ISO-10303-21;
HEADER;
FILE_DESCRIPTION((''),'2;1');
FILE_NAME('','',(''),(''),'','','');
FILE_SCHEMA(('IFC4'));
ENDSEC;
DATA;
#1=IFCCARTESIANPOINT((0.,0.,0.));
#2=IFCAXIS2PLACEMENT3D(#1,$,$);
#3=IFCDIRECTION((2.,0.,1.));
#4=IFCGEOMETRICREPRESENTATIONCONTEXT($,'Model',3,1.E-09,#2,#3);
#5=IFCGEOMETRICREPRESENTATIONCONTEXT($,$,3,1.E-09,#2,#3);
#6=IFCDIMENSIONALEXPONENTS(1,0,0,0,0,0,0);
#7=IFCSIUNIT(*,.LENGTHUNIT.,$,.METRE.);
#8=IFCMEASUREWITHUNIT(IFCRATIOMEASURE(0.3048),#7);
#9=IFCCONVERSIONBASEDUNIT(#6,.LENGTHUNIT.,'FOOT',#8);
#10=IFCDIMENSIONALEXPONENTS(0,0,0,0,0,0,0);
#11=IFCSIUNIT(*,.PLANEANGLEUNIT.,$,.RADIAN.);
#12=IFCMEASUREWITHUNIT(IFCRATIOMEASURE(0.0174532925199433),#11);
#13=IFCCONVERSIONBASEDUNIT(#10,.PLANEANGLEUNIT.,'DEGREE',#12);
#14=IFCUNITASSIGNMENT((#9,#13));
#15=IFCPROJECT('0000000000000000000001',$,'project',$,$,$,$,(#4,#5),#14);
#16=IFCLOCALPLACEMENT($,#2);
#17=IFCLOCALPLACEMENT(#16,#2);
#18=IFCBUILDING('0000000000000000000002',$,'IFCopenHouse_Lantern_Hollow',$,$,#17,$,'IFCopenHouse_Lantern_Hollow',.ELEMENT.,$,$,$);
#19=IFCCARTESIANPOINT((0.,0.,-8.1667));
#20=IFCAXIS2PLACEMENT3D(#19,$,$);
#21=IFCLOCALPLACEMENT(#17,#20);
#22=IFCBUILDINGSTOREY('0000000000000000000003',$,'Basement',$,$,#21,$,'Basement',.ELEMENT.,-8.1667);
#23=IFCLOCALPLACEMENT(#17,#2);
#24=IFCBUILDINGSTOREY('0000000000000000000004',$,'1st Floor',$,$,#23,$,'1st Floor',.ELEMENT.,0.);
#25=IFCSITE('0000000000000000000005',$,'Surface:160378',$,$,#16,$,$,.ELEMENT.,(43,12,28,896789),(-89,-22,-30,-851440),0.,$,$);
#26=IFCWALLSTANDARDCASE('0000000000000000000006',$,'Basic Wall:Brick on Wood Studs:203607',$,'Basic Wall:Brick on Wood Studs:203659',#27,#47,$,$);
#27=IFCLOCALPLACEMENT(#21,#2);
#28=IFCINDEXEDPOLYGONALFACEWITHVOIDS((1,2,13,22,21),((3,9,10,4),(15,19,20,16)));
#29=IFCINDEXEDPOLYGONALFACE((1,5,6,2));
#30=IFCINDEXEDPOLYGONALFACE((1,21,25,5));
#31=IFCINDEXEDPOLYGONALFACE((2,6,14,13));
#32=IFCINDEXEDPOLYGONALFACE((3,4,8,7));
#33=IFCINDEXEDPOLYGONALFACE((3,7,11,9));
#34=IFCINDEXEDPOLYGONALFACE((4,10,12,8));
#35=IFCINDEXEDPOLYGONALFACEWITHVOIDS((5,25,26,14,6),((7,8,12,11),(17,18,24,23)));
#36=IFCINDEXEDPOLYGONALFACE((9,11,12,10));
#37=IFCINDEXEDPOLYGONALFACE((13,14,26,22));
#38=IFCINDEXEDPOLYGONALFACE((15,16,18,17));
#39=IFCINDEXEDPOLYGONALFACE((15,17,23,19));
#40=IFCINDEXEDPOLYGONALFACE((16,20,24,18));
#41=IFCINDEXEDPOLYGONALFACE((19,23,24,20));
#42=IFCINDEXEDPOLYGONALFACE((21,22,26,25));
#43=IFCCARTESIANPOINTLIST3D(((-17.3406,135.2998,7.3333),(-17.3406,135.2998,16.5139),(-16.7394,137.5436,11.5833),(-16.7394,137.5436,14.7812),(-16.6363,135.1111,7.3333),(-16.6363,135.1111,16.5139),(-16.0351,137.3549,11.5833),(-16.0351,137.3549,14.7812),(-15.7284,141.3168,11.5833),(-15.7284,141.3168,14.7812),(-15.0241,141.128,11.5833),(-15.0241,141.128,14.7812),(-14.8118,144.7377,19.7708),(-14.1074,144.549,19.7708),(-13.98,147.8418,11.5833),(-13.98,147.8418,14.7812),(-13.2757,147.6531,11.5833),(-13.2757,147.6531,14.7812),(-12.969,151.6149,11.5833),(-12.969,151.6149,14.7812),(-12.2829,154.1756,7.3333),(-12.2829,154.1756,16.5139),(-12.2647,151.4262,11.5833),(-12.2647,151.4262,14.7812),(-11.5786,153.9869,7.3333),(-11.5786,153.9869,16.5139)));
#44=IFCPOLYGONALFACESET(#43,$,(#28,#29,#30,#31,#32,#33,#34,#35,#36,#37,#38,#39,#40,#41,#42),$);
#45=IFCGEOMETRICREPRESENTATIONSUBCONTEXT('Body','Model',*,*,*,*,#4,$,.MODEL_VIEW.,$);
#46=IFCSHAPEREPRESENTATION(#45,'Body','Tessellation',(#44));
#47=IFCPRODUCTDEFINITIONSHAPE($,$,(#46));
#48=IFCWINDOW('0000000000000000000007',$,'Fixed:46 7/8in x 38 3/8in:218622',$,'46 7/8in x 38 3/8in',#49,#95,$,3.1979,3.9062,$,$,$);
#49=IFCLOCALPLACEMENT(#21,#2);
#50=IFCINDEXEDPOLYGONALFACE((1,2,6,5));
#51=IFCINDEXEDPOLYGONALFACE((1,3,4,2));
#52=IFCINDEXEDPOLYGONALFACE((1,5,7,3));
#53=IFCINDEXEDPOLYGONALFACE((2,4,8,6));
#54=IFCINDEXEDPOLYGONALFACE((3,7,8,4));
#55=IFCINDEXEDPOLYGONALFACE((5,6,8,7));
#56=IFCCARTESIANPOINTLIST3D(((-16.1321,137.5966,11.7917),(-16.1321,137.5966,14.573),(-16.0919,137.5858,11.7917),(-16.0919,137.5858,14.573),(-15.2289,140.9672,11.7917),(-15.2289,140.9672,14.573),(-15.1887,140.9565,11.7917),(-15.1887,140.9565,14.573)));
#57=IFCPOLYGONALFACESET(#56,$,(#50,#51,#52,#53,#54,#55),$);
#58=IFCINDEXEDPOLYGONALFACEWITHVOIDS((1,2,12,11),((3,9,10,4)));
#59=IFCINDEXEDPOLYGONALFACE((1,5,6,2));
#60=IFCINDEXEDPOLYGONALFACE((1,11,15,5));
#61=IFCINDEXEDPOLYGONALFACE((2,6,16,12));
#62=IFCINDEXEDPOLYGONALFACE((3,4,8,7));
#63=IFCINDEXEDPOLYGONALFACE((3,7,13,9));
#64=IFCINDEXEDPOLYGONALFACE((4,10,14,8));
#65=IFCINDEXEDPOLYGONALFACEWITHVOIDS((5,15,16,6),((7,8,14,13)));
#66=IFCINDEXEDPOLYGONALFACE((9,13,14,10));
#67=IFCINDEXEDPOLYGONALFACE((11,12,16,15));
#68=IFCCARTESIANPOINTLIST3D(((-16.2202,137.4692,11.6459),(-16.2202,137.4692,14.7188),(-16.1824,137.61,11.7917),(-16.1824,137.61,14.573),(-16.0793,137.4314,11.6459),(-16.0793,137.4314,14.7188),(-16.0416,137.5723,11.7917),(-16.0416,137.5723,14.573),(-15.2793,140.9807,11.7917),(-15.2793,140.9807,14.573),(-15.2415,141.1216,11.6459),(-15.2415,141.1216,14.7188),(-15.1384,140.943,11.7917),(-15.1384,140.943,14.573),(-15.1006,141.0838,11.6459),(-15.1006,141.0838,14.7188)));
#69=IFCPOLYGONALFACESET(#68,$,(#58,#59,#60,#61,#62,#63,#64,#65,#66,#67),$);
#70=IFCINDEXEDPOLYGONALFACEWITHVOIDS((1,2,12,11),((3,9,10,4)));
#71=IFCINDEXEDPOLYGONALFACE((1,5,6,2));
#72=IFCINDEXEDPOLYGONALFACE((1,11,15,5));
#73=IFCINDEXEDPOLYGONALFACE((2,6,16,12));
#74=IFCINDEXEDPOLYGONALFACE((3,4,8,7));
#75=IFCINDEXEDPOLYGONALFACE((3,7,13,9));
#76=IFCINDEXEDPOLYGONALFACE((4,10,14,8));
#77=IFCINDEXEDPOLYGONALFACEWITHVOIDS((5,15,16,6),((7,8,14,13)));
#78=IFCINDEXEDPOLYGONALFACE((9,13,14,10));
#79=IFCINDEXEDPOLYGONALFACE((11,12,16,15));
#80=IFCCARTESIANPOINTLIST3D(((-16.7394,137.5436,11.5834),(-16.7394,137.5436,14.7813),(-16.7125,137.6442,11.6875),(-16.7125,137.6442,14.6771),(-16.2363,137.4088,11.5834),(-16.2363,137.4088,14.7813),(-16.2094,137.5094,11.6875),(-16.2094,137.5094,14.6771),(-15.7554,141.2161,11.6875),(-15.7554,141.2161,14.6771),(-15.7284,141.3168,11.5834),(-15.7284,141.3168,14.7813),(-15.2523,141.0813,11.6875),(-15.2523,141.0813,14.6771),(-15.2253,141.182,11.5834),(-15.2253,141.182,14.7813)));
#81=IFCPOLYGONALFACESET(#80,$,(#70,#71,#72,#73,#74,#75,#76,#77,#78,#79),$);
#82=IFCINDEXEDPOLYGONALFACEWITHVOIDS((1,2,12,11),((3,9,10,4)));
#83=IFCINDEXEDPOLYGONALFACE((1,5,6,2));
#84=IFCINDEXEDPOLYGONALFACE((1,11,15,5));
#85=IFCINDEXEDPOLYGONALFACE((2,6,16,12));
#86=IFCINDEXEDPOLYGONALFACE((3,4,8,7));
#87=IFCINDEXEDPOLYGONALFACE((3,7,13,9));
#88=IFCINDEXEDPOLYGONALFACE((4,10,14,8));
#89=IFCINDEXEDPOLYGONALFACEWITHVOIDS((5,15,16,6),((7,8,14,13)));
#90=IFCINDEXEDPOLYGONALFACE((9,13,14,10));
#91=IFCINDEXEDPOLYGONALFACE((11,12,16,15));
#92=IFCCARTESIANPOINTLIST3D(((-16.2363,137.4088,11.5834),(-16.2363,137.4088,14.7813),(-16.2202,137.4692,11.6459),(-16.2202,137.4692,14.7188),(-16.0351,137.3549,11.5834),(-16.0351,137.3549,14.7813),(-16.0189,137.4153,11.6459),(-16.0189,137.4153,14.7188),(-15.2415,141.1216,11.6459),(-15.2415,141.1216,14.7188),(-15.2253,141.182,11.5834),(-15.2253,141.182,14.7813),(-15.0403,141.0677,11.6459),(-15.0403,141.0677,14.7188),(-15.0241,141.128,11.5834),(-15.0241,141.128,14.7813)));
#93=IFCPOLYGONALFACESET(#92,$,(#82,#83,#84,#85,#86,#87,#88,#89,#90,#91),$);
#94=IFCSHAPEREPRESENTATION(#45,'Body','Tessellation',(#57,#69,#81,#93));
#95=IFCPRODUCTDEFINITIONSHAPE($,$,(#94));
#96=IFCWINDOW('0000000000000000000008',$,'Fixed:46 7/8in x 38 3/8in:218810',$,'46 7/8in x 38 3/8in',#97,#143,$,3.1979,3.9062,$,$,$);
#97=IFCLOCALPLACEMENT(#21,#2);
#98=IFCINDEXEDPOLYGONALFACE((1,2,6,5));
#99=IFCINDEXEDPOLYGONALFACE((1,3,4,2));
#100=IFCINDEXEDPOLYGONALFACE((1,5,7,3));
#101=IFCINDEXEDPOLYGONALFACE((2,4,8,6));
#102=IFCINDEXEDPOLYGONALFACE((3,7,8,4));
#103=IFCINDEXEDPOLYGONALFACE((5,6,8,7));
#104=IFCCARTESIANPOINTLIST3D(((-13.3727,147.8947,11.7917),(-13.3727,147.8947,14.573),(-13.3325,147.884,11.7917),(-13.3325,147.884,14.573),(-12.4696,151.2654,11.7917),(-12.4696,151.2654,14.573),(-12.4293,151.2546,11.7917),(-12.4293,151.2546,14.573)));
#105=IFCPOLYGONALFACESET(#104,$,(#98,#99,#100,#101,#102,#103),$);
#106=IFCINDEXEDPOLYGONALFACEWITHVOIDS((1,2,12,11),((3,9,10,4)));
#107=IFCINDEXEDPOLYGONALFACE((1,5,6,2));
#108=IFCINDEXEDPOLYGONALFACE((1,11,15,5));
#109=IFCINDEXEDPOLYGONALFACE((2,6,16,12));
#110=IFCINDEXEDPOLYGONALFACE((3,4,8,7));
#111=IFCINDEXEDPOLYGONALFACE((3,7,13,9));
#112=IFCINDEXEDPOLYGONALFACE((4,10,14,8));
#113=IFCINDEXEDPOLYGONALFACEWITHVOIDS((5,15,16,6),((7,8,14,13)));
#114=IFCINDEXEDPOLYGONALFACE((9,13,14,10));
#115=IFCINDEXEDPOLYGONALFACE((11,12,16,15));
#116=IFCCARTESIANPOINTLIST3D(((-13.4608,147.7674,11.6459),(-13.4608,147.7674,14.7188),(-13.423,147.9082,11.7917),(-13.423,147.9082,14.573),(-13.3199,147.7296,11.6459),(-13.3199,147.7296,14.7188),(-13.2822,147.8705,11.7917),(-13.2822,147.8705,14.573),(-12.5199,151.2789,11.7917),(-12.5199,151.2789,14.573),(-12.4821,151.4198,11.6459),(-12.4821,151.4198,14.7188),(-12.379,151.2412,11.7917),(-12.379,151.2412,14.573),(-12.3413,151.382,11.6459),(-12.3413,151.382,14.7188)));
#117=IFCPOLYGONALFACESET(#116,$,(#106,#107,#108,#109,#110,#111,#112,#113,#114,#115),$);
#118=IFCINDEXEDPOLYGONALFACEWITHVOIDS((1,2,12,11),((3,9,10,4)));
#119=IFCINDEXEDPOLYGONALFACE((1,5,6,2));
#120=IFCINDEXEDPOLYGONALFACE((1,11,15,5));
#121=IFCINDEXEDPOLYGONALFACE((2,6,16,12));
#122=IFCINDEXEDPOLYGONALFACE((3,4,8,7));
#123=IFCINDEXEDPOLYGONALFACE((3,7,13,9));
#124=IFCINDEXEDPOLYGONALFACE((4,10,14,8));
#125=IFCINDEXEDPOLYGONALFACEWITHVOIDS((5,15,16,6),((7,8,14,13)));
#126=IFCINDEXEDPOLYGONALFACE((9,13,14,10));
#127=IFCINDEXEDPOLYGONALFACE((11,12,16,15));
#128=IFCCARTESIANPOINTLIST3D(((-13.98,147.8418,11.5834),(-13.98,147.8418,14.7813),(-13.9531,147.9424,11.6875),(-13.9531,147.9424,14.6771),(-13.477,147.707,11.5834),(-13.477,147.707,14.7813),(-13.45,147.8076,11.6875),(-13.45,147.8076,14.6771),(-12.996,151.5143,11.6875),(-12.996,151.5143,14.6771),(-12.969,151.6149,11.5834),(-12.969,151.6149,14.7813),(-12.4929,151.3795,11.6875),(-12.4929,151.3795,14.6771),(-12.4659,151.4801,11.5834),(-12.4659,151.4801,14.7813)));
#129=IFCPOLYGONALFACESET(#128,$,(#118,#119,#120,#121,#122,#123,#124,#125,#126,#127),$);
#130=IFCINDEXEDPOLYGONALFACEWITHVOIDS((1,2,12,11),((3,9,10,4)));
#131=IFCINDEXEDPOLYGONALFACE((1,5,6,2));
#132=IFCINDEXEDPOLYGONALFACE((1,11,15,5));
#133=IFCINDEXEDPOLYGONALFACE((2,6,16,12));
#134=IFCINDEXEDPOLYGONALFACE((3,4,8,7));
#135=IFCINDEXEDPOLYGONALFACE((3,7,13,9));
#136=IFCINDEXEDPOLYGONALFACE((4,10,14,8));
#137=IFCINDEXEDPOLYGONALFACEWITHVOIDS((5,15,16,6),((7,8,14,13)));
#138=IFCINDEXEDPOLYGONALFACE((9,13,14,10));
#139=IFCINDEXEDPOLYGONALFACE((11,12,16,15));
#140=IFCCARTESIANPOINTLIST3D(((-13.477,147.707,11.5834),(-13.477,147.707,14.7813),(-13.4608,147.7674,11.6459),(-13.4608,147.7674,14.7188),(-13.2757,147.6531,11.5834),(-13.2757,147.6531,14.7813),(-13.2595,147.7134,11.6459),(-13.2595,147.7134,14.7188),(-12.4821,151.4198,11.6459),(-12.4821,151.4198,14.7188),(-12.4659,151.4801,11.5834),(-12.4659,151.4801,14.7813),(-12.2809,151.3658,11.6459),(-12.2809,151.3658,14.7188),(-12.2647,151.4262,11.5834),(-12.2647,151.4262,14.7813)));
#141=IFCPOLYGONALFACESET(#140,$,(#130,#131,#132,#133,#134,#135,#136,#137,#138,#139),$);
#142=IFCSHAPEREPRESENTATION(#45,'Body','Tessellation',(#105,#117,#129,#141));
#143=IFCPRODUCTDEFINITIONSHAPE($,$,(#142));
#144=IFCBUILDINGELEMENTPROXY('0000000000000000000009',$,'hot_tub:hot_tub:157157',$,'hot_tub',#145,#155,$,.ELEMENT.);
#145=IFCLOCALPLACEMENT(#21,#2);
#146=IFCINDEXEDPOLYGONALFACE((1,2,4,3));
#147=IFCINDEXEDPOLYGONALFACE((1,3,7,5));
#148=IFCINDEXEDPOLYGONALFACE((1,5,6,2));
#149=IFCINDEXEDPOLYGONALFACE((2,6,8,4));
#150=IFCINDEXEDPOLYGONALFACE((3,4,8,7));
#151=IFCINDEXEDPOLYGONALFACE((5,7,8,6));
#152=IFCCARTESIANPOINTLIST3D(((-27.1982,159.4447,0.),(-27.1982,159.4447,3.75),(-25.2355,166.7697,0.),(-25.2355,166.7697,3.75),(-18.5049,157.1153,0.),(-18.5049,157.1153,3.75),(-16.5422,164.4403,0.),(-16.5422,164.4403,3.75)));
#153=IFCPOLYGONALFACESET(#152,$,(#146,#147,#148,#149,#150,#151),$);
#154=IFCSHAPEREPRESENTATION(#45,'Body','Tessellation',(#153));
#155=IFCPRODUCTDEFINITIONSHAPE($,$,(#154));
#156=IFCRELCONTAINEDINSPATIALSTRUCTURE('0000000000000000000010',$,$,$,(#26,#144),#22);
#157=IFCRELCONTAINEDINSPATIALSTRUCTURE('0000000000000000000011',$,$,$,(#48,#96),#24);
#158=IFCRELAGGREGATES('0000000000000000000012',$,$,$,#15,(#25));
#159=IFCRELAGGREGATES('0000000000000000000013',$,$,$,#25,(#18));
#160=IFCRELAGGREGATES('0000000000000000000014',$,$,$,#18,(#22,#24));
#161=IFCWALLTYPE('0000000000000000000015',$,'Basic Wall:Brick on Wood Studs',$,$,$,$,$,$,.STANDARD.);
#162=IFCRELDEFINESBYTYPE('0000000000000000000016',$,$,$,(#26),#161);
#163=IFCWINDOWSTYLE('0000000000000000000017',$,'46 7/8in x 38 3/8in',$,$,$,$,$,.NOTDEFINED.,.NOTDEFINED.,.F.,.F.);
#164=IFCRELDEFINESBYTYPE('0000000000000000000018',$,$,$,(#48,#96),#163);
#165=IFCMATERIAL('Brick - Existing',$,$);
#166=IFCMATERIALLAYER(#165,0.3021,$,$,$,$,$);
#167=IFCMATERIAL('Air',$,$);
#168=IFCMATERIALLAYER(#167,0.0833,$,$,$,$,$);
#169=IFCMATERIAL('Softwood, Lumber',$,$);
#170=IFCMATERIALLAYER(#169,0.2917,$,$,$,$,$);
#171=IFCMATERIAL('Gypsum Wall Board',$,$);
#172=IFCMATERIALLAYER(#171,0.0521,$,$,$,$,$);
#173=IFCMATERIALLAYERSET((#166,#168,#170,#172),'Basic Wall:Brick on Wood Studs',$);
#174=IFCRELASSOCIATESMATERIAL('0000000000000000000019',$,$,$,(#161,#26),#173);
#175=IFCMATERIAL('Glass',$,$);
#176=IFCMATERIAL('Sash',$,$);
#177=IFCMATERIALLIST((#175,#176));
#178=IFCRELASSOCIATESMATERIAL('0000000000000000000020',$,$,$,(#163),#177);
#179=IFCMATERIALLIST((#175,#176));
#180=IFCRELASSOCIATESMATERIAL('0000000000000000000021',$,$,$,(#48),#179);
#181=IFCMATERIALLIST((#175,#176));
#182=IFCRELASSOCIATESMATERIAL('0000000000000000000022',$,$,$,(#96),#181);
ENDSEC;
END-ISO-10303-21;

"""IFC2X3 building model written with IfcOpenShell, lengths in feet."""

from ifc_helpers import new_model, entity, si_unit, converted_unit, direction, frame, frame_2d, origin, origin_2d_with_axis, place, context, subcontext, project, spatial, polyline, rectangle, outline, extrude, clip, bounded_halfspace, source, transform, mapped, material, material_list, layer, layer_set, layer_usage, type_object, type_shapes, element, fill, save


model = new_model("IFC2X3")

# Units and contexts
model_context = context("Model", 3, precision=1e-09, world=origin(), true_north=direction((2.0, 0.0, 1.0)))
context_of_model = context(None, 3, precision=1e-09, world=origin(), true_north=direction((2.0, 0.0, 1.0)))
body_context = subcontext(model_context, "Body", "Model", "MODEL_VIEW")
ifc_project = project(units=[converted_unit("LENGTHUNIT", "FOOT", entity("IfcRatioMeasure", 0.3048), si_unit("LENGTHUNIT", "METRE"), dimensions=[1, 0, 0, 0, 0, 0, 0]), converted_unit("PLANEANGLEUNIT", "DEGREE", entity("IfcRatioMeasure", 0.0174532925199433), si_unit("PLANEANGLEUNIT", "RADIAN"), dimensions=[0, 0, 0, 0, 0, 0, 0])], contexts=[model_context, context_of_model])

# Site, building, storey
site_placement = place(None, origin())
site = spatial("IfcSite", under=ifc_project, at=site_placement, Name="Surface:160378", CompositionType="ELEMENT", RefLatitude=(43, 12, 28, 896789), RefLongitude=(-89, -22, -30, -851440), RefElevation=0.0)
building_placement = place(site_placement, origin())
building = spatial("IfcBuilding", under=site, at=building_placement, Name="IFCopenHouse_Lantern_Hollow", LongName="IFCopenHouse_Lantern_Hollow", CompositionType="ELEMENT")
storey_1_placement = place(building_placement, frame((0.0, 0.0, -8.1667)))
storey_1 = spatial("IfcBuildingStorey", under=building, at=storey_1_placement, Name="Basement", LongName="Basement", CompositionType="ELEMENT", Elevation=-8.1667)

# Shared definitions
ifc_material_1 = material(Name="Brick - Existing")
ifc_material_2 = material(Name="Air")
ifc_material_3 = material(Name="Softwood, Lumber")
ifc_material_4 = material(Name="Gypsum Wall Board")
ifc_material_5 = material(Name="Glass")
ifc_material_6 = material(Name="Sash")

# Wall, openings
ifc_layer_1 = layer(ifc_material_1, 0.3021)
ifc_layer_2 = layer(ifc_material_2, 0.0833)
ifc_layer_3 = layer(ifc_material_3, 0.2917)
ifc_layer_4 = layer(ifc_material_4, 0.0521)
ifc_layer_set_1 = layer_set([ifc_layer_1, ifc_layer_2, ifc_layer_3, ifc_layer_4], Name="Basic Wall:Brick on Wood Studs")
ifc_layer_usage_1 = layer_usage(ifc_layer_set_1, "AXIS2", "NEGATIVE", 0.3646)
wall_type_1 = type_object("IfcWallType", Name="Basic Wall:Brick on Wood Studs", PredefinedType="STANDARD", material=ifc_layer_set_1)
wall_1_placement = place(storey_1_placement, frame((-11.9307, 154.0813, 7.3333), z_axis=(0.0, 0.0, 1.0), x_axis=(-0.258819, -0.965926, 0.0)))
wall_1 = element("IfcWallStandardCase", 1, at=wall_1_placement, inside=storey_1, type_object=wall_type_1, material=ifc_layer_usage_1, Name="Basic Wall:Brick on Wood Studs:203607", ObjectType="Basic Wall:Brick on Wood Studs:203659", context=body_context, shape_type="Clipping", body=[
    clip(clip(extrude(rectangle(XDim=19.5417, YDim=0.7292, at=frame_2d((9.7708, 0.0), x_axis=(-1.0, 0.0))), origin(), (0.0, 0.0, 1.0), 12.4375), bounded_halfspace(frame((9.7708, -0.3646, 12.4375), z_axis=(0.316228, 0.0, 0.948683), x_axis=(0.0, 1.0, 0.0)), False, frame((9.7708, -0.3646, 12.4375)), polyline([(0.0, 0.0), (9.7708, 0.0), (9.7708, 0.7292), (0.0, 0.7292), (0.0, 0.0)]))), bounded_halfspace(frame((0.0, -0.3646, 9.1806), z_axis=(-0.316228, 0.0, 0.948683), x_axis=(0.0, -1.0, 0.0)), False, frame((0.0, -0.3646, 9.1806)), polyline([(0.0, 0.0), (9.7708, 0.0), (9.7708, 0.7292), (0.0, 0.7292), (0.0, 0.0)]))),
])
opening_1_placement = place(wall_1_placement, frame((13.3125, -0.3646, 4.25)))
opening_1 = element("IfcOpeningElement", 2, at=opening_1_placement, cuts=wall_1, ObjectType="Opening", context=body_context, shape_type="SweptSolid", body=[
    extrude(rectangle(XDim=3.1979, YDim=3.9062, at=frame_2d((1.599, 1.9531), x_axis=(-1.0, 0.0))), frame((0.0, 0.0, 0.0), z_axis=(0.0, 1.0, 0.0), x_axis=(0.0, 0.0, 1.0)), (0.0, 0.0, 1.0), 0.7292),
])
opening_2_placement = place(wall_1_placement, frame((2.651, -0.3646, 4.25)))
opening_2 = element("IfcOpeningElement", 3, at=opening_2_placement, cuts=wall_1, ObjectType="Opening", context=body_context, shape_type="SweptSolid", body=[
    extrude(rectangle(XDim=3.1979, YDim=3.9062, at=frame_2d((1.599, 1.9531), x_axis=(-1.0, 0.0))), frame((0.0, 0.0, 0.0), z_axis=(0.0, 1.0, 0.0), x_axis=(0.0, 0.0, 1.0)), (0.0, 0.0, 1.0), 0.7292),
])

# Shared definitions
storey_2_placement = place(building_placement, origin())
storey_2 = spatial("IfcBuildingStorey", under=building, at=storey_2_placement, Name="1st Floor", LongName="1st Floor", CompositionType="ELEMENT", Elevation=0.0)

# Windows
ifc_material_list_1 = material_list([ifc_material_5, ifc_material_6])
ifc_material_list_2 = material_list([ifc_material_5, ifc_material_6])
window_style_1 = type_object("IfcWindowStyle", Name="46 7/8in x 38 3/8in", ConstructionType="NOTDEFINED", OperationType="NOTDEFINED", ParameterTakesPrecedence=False, Sizeable=False, material=ifc_material_list_2)
shared_shape_1 = source(origin(), body_context, "Body", "SweptSolid", [
    extrude(rectangle(XDim=0.0417, YDim=3.4896, at=frame_2d((0.0, 0.0), x_axis=(1.0, 0.0))), frame((1.9531, 0.5938, 0.2083), z_axis=(0.0, 0.0, 1.0), x_axis=(0.0, 1.0, 0.0)), (0.0, 0.0, 1.0), 2.7813),
    extrude(outline(polyline([(-1.8906, -1.5365), (1.8906, -1.5365), (1.8906, 1.5365), (-1.8906, 1.5365), (-1.8906, -1.5365)]), holes=[polyline([(-1.7448, -1.3906), (-1.7448, 1.3906), (1.7448, 1.3906), (1.7448, -1.3906), (-1.7448, -1.3906)])]), frame((1.9531, 0.5208, 1.599), z_axis=(0.0, 1.0, 0.0), x_axis=(1.0, 0.0, 0.0)), (0.0, 0.0, 1.0), 0.1458),
    extrude(outline(polyline([(-1.9531, -1.599), (1.9531, -1.599), (1.9531, 1.599), (-1.9531, 1.599), (-1.9531, -1.599)]), holes=[polyline([(-1.849, -1.4948), (-1.849, 1.4948), (1.849, 1.4948), (1.849, -1.4948), (-1.849, -1.4948)])]), frame((1.9531, 0.0, 1.599), z_axis=(0.0, 1.0, 0.0), x_axis=(1.0, 0.0, 0.0)), (0.0, 0.0, 1.0), 0.5208),
    extrude(outline(polyline([(-1.599, -1.9531), (1.599, -1.9531), (1.599, 1.9531), (-1.599, 1.9531), (-1.599, -1.9531)]), holes=[polyline([(-1.5365, -1.8906), (-1.5365, 1.8906), (1.5365, 1.8906), (1.5365, -1.8906), (-1.5365, -1.8906)])]), frame((1.9531, 0.5208, 1.599), z_axis=(0.0, 1.0, 0.0), x_axis=(0.0, 0.0, -1.0)), (0.0, 0.0, 1.0), 0.2083),
])
type_shapes(window_style_1, [shared_shape_1])
window_1_placement = place(storey_2_placement, frame((-15.7284, 141.3168, 3.4167), z_axis=(0.0, 0.0, 1.0), x_axis=(-0.258819, -0.965926, 0.0)))
window_1 = element("IfcWindow", 4, at=window_1_placement, inside=storey_2, type_object=window_style_1, material=ifc_material_list_1, Name="Fixed:46 7/8in x 38 3/8in:218622", ObjectType="46 7/8in x 38 3/8in", OverallHeight=3.1979, OverallWidth=3.9062, context=body_context, shape_type="MappedRepresentation", body=[
    mapped(shared_shape_1, transform((0.0, 0.0, 0.0), scale=1.0)),
])
fill(opening_1, window_1)
ifc_material_list_3 = material_list([ifc_material_5, ifc_material_6])
window_2_placement = place(storey_2_placement, frame((-12.969, 151.6149, 3.4167), z_axis=(0.0, 0.0, 1.0), x_axis=(-0.258819, -0.965926, 0.0)))
window_2 = element("IfcWindow", 5, at=window_2_placement, inside=storey_2, type_object=window_style_1, material=ifc_material_list_3, Name="Fixed:46 7/8in x 38 3/8in:218810", ObjectType="46 7/8in x 38 3/8in", OverallHeight=3.1979, OverallWidth=3.9062, context=body_context, shape_type="MappedRepresentation", body=[
    mapped(shared_shape_1, transform((0.0, 0.0, 0.0), scale=1.0)),
])
fill(opening_2, window_2)

# Building element proxy
shared_shape_2 = source(origin(), body_context, "Body", "SweptSolid", [
    extrude(rectangle(XDim=7.5833, YDim=9.0, at=origin_2d_with_axis()), frame((4.5, 3.7917, 0.0), z_axis=(0.0, 0.0, 1.0), x_axis=(0.0, 1.0, 0.0)), (0.0, 0.0, 1.0), 3.75),
])
proxy_placement = place(storey_1_placement, frame((-27.1982, 159.4447, 0.0), z_axis=(0.0, 0.0, 1.0), x_axis=(0.965926, -0.258819, 0.0)))
element("IfcBuildingElementProxy", 6, at=proxy_placement, inside=storey_1, Name="hot_tub:hot_tub:157157", ObjectType="hot_tub", CompositionType="ELEMENT", context=body_context, shape_type="MappedRepresentation", body=[
    mapped(shared_shape_2, transform((0.0, 0.0, 0.0), scale=1.0)),
])

save(model, "model.ifc")
